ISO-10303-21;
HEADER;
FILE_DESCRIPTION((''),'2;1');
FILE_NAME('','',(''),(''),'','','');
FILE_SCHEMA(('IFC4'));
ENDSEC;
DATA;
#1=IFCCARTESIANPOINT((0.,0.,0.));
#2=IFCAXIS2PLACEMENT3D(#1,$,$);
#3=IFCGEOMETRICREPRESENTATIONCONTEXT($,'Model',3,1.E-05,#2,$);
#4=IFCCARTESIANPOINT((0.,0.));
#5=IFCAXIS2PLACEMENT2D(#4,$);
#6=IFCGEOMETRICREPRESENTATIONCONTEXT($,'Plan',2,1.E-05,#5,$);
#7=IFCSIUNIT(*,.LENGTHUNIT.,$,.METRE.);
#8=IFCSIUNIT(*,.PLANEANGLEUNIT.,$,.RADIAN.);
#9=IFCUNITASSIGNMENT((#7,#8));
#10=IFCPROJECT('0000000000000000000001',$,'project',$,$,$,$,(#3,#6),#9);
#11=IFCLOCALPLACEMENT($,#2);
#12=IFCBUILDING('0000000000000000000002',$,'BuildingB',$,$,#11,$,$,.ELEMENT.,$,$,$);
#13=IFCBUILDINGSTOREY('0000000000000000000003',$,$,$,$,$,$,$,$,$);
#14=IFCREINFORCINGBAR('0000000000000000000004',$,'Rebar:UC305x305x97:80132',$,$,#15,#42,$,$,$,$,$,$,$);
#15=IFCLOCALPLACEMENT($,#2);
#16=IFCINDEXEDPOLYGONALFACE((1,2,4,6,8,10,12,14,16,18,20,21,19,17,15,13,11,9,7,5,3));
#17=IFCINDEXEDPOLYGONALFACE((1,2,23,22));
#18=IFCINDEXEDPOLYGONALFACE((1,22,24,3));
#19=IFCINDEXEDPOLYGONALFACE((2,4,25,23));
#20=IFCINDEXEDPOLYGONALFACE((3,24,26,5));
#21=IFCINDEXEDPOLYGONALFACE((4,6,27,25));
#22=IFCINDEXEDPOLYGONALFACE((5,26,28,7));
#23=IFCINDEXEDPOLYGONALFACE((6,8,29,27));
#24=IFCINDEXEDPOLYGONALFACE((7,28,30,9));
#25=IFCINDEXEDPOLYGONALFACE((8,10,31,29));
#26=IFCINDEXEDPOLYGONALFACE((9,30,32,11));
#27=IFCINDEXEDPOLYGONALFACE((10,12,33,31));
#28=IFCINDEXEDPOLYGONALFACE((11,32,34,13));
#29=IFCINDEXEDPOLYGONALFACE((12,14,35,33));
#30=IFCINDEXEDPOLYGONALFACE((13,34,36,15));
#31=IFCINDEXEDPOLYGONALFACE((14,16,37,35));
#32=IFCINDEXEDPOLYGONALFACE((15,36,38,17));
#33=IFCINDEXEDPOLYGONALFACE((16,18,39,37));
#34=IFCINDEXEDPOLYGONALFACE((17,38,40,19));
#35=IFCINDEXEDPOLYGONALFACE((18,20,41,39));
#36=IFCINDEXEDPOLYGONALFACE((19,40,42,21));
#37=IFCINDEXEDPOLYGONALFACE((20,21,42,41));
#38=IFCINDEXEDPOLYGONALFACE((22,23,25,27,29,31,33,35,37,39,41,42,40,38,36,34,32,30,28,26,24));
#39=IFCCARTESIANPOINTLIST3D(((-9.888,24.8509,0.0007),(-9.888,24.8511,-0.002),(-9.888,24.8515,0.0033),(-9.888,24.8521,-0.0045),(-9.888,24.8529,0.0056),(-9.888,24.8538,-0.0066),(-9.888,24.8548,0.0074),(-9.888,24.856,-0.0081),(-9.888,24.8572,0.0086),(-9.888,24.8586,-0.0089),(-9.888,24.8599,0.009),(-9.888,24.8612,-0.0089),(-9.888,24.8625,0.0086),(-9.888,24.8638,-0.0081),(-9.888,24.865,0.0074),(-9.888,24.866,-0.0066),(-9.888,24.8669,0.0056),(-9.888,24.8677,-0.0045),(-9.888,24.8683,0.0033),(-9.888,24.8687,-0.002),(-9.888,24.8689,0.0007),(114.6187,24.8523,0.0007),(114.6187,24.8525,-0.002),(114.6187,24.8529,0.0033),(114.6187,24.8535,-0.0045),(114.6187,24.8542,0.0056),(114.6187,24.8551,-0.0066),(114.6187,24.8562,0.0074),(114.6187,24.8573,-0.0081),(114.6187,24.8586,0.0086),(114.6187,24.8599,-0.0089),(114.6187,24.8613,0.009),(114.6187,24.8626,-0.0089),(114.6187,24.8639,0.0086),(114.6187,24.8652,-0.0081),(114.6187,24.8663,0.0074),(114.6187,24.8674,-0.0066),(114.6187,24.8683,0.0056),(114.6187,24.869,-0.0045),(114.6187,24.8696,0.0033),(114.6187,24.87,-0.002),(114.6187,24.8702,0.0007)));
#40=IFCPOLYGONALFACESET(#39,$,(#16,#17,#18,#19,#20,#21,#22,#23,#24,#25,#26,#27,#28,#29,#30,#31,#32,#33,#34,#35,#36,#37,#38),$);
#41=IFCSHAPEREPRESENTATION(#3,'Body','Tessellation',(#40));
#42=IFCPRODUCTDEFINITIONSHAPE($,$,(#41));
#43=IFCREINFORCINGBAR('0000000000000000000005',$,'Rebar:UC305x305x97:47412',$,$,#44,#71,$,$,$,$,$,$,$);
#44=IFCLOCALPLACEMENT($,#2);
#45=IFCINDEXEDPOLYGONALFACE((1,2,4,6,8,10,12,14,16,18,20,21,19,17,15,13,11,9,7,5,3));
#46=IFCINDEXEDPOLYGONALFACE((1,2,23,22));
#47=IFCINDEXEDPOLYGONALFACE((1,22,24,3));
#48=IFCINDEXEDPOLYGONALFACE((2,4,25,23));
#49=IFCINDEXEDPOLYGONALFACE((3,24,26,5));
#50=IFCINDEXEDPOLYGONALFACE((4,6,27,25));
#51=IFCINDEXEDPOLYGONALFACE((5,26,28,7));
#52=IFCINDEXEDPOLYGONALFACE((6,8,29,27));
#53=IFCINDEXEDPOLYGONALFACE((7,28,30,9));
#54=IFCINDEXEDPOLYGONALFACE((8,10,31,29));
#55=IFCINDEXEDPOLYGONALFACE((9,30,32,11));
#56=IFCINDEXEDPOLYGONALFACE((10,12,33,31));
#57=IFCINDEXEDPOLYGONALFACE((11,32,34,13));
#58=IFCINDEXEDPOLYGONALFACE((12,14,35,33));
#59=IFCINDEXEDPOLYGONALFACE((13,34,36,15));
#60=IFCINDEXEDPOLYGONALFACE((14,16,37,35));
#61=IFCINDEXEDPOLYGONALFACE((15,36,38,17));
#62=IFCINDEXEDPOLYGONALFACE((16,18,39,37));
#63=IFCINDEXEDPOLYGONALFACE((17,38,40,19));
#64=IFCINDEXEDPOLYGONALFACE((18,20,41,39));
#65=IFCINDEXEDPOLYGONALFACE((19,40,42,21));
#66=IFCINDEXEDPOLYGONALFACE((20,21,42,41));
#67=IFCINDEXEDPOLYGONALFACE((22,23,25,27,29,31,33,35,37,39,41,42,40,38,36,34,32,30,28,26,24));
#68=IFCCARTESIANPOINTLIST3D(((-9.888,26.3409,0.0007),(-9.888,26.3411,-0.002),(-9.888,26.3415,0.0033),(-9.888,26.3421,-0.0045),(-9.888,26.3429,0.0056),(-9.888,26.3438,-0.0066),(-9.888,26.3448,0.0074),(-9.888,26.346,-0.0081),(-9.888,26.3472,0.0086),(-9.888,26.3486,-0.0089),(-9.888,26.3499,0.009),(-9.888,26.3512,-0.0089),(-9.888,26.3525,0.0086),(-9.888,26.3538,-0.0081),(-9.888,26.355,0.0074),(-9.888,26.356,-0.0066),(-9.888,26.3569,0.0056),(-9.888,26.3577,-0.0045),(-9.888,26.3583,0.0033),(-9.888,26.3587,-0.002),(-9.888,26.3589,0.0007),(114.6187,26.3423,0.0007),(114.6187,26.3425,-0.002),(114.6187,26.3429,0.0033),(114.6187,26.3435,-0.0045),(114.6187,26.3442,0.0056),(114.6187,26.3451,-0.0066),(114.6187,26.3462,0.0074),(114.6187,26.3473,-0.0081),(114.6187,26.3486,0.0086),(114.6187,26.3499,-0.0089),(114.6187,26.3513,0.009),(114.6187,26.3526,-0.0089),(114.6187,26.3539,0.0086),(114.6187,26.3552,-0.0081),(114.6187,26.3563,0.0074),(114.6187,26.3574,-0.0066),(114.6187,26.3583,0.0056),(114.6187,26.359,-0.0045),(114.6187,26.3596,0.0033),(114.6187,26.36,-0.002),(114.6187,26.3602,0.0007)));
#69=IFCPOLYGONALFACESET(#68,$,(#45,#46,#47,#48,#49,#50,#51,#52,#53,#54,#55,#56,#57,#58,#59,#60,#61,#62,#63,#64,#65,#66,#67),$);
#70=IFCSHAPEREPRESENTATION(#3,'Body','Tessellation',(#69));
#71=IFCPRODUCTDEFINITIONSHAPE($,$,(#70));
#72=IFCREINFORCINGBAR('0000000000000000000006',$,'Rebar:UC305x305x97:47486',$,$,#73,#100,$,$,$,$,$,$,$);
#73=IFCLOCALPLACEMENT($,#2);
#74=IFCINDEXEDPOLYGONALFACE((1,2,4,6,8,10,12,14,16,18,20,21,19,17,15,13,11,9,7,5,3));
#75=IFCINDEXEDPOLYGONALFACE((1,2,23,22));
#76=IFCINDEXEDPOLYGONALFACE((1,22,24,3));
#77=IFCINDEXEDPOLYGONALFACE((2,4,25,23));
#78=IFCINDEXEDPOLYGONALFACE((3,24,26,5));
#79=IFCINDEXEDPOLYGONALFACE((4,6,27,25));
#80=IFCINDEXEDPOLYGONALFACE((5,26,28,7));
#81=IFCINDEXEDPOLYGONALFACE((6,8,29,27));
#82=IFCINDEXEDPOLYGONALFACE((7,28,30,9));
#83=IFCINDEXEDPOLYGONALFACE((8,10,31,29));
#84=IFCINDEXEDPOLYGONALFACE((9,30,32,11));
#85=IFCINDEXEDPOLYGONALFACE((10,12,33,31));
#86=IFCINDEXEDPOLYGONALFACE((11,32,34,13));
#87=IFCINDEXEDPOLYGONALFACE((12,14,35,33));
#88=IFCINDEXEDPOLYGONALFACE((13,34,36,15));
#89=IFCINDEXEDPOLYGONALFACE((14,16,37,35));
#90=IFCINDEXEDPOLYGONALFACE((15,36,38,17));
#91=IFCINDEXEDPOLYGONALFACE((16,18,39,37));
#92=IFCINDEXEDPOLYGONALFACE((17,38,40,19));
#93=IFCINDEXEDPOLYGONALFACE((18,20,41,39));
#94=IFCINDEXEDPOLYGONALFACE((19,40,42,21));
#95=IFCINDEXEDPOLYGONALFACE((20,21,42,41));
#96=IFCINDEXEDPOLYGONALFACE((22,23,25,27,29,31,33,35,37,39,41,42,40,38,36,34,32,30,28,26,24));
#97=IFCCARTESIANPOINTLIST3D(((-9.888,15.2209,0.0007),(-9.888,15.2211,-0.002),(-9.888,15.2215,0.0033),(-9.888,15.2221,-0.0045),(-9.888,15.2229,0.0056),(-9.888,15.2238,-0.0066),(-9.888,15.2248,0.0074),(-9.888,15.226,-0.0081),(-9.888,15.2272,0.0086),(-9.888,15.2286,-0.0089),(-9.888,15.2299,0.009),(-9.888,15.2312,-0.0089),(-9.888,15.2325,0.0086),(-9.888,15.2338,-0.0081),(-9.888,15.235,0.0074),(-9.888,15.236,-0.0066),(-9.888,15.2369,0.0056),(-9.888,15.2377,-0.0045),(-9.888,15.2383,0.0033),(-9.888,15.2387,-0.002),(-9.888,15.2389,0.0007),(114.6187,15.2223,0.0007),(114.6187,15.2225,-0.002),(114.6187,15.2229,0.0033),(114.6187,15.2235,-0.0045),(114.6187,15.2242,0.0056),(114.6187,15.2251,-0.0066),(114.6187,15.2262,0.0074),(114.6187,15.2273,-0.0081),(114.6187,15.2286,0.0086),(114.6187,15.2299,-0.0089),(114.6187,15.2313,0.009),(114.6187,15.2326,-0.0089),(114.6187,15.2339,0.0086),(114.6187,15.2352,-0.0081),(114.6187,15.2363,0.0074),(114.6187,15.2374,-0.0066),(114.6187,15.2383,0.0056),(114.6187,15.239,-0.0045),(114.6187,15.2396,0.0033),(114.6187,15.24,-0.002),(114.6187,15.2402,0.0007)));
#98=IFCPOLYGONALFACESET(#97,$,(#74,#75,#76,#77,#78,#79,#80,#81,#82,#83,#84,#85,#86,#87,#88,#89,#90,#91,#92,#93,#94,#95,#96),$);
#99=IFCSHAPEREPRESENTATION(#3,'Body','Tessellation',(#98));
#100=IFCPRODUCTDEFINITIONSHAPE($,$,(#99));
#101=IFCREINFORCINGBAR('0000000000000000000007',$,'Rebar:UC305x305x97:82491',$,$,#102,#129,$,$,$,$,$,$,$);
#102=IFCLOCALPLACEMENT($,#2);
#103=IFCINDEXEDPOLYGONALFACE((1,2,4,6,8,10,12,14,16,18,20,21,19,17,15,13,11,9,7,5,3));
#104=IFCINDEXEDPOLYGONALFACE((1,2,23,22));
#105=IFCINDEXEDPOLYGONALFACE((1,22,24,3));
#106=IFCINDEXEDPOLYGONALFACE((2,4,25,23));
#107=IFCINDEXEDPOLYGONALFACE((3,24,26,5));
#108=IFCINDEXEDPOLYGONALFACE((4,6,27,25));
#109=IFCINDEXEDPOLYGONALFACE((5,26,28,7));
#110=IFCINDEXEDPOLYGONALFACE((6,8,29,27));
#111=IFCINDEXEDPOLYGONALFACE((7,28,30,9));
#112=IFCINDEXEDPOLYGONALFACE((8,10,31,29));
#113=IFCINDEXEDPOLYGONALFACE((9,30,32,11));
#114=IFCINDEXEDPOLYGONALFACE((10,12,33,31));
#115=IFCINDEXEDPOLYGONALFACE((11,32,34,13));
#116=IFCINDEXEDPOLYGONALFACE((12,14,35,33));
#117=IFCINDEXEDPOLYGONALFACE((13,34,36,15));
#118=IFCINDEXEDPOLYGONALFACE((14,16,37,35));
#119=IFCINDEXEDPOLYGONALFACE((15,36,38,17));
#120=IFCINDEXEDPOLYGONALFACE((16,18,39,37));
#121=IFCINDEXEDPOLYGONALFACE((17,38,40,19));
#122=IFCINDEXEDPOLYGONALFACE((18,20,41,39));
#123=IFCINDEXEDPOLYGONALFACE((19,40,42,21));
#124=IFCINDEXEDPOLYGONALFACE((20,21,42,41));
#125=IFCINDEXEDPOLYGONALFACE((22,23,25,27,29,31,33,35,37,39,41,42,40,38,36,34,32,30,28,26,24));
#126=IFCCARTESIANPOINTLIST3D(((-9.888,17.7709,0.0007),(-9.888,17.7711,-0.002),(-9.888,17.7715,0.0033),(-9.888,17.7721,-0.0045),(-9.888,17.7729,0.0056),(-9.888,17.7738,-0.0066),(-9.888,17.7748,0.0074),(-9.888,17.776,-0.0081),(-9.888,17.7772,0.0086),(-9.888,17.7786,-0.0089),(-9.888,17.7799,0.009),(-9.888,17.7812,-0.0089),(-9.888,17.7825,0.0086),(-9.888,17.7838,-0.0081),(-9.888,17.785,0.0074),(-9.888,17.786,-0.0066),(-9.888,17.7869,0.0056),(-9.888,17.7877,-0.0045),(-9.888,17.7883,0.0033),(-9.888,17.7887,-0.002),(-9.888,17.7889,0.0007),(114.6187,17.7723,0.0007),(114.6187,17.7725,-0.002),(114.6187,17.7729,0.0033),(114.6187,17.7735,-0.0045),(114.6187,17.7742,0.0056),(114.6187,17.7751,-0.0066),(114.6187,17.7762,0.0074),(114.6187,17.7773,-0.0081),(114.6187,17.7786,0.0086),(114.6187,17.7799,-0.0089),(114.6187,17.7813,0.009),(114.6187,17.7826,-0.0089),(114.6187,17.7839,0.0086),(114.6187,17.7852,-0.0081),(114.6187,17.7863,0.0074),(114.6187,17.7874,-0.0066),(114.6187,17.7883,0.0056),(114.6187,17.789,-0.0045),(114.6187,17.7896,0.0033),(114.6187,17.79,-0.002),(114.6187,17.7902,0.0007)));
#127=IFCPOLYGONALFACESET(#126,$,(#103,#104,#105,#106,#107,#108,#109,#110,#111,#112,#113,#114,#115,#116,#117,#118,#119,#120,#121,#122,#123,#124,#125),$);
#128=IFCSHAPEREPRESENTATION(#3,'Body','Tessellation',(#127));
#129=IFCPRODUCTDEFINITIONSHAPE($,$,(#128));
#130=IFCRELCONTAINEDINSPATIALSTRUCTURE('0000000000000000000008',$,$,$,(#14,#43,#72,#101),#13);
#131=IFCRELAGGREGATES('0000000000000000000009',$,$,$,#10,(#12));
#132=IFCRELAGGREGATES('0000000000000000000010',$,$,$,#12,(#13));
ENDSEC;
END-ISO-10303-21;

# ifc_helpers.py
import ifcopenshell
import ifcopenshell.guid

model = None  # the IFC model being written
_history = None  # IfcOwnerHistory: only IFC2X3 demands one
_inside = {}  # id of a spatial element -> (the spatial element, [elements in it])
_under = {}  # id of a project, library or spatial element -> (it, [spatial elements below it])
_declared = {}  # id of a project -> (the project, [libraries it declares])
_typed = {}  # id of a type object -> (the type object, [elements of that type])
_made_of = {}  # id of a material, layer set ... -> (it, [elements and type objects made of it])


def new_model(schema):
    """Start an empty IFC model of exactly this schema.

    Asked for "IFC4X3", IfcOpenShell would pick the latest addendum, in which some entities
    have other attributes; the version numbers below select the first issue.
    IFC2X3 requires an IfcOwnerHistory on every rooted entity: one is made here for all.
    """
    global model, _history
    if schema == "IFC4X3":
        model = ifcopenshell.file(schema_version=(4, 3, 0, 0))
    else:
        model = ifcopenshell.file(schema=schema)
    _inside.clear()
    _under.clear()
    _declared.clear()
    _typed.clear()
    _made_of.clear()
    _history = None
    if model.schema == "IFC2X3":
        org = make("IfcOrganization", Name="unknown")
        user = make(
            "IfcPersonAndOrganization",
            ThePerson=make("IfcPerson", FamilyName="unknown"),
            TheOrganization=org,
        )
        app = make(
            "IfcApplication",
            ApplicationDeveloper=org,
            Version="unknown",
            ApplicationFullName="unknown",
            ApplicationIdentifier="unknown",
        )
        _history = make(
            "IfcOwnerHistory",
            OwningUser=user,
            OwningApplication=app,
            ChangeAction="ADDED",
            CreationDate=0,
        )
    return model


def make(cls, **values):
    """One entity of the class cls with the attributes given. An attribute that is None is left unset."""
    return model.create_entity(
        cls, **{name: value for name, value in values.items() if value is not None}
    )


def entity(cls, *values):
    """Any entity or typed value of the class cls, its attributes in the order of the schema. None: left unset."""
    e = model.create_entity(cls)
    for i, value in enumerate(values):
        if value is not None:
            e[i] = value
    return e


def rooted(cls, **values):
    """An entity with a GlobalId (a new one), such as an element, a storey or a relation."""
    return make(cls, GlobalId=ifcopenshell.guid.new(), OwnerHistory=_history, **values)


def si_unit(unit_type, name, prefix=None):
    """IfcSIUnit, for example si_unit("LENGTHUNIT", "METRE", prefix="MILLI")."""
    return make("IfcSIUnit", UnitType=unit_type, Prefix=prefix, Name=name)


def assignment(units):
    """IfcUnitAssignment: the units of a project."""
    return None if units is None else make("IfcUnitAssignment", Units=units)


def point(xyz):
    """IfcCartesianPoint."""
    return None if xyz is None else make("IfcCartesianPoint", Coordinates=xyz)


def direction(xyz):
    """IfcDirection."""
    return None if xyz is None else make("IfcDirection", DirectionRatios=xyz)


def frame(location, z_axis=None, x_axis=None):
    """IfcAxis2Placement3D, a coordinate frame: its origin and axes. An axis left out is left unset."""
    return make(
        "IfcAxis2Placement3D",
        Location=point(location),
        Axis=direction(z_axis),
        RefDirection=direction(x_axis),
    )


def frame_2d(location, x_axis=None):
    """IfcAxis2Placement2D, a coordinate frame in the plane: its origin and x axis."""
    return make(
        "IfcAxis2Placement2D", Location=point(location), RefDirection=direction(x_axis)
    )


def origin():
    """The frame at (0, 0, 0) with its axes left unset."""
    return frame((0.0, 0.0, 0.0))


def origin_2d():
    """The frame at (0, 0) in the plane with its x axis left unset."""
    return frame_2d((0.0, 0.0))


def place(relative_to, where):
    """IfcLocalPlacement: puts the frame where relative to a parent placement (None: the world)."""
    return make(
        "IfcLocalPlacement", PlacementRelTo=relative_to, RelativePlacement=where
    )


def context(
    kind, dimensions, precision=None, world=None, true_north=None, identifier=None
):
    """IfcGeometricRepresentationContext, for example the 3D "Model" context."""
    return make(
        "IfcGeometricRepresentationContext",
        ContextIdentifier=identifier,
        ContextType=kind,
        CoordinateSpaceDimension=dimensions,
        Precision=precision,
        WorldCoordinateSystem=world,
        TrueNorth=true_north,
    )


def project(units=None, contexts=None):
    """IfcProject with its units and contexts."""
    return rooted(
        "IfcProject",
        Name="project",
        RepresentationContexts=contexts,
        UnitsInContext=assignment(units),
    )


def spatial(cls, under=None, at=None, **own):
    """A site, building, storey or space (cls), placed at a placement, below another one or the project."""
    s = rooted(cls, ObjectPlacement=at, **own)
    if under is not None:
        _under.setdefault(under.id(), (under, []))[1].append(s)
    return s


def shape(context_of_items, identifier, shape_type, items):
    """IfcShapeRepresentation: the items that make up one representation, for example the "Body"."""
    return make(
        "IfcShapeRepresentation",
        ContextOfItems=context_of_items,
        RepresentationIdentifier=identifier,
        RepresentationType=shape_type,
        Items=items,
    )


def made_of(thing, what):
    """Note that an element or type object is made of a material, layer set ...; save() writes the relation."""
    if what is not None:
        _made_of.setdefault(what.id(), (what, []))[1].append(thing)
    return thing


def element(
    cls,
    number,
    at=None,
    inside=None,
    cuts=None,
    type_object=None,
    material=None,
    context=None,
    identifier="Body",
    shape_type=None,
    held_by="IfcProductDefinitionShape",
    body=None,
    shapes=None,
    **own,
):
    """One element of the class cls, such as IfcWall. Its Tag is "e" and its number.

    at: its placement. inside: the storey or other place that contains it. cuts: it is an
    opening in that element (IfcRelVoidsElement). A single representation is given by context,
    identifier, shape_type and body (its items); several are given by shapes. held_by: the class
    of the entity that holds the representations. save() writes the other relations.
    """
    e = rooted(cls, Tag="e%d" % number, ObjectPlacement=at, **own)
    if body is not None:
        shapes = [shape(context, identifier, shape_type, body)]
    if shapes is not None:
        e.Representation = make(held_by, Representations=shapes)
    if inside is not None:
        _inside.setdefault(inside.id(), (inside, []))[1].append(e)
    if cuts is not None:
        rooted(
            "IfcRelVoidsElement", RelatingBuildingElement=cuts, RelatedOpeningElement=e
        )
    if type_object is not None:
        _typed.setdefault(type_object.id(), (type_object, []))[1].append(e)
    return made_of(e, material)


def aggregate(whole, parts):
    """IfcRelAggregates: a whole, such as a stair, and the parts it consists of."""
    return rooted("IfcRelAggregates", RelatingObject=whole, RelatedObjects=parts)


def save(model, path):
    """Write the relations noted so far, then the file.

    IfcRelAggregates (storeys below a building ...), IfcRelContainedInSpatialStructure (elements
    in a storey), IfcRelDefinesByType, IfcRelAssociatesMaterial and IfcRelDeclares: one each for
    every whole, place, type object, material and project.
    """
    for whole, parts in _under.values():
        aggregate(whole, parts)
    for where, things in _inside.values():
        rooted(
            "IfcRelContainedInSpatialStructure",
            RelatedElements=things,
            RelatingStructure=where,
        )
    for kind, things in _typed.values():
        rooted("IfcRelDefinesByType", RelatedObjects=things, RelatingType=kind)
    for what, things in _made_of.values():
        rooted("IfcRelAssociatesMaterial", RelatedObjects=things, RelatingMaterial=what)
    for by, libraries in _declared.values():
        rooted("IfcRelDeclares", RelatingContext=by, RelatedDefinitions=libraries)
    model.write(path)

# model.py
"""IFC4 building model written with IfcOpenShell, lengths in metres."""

from ifc_helpers import new_model, entity, si_unit, origin, origin_2d, place, context, project, spatial, element, save


model = new_model("IFC4")

# Units and contexts
model_context = context("Model", 3, precision=1e-05, world=origin())
plan_context = context("Plan", 2, precision=1e-05, world=origin_2d())
ifc_project = project(units=[si_unit("LENGTHUNIT", "METRE"), si_unit("PLANEANGLEUNIT", "RADIAN")], contexts=[model_context, plan_context])

# Building, storey
building_placement = place(None, origin())
building = spatial("IfcBuilding", under=ifc_project, at=building_placement, Name="BuildingB", CompositionType="ELEMENT")
storey = spatial("IfcBuildingStorey", under=building)

# Reinforcing bars
element("IfcReinforcingBar", 1, inside=storey, Name="Rebar:UC305x305x97:80132", context=model_context, shape_type="SweptSolid", body=[
    entity("IfcSurfaceCurveSweptAreaSolid", entity("IfcCircleProfileDef", "AREA", None, None, 0.009), None, entity("IfcPolyline", [entity("IfcCartesianPoint", [-9.888, 24.8599, 0.0]), entity("IfcCartesianPoint", [114.6187, 24.8613, 0.0])]), None, None, entity("IfcPlane", entity("IfcAxis2Placement3D", entity("IfcCartesianPoint", [-9.888, 24.8599, 0.0]), entity("IfcDirection", [0.0, 0.0, 1.0]), entity("IfcDirection", [1.0, 0.0, 0.0])))),
])
element("IfcReinforcingBar", 2, inside=storey, Name="Rebar:UC305x305x97:47412", context=model_context, shape_type="SweptSolid", body=[
    entity("IfcSurfaceCurveSweptAreaSolid", entity("IfcCircleProfileDef", "AREA", None, None, 0.009), None, entity("IfcPolyline", [entity("IfcCartesianPoint", [-9.888, 26.3499, 0.0]), entity("IfcCartesianPoint", [114.6187, 26.3513, 0.0])]), None, None, entity("IfcPlane", entity("IfcAxis2Placement3D", entity("IfcCartesianPoint", [-9.888, 26.3499, 0.0]), entity("IfcDirection", [0.0, 0.0, 1.0]), entity("IfcDirection", [1.0, 0.0, 0.0])))),
])
element("IfcReinforcingBar", 3, inside=storey, Name="Rebar:UC305x305x97:47486", context=model_context, shape_type="SweptSolid", body=[
    entity("IfcSurfaceCurveSweptAreaSolid", entity("IfcCircleProfileDef", "AREA", None, None, 0.009), None, entity("IfcPolyline", [entity("IfcCartesianPoint", [-9.888, 15.2299, 0.0]), entity("IfcCartesianPoint", [114.6187, 15.2313, 0.0])]), None, None, entity("IfcPlane", entity("IfcAxis2Placement3D", entity("IfcCartesianPoint", [-9.888, 15.2299, 0.0]), entity("IfcDirection", [0.0, 0.0, 1.0]), entity("IfcDirection", [1.0, 0.0, 0.0])))),
])
element("IfcReinforcingBar", 4, inside=storey, Name="Rebar:UC305x305x97:82491", context=model_context, shape_type="SweptSolid", body=[
    entity("IfcSurfaceCurveSweptAreaSolid", entity("IfcCircleProfileDef", "AREA", None, None, 0.009), None, entity("IfcPolyline", [entity("IfcCartesianPoint", [-9.888, 17.7799, 0.0]), entity("IfcCartesianPoint", [114.6187, 17.7813, 0.0])]), None, None, entity("IfcPlane", entity("IfcAxis2Placement3D", entity("IfcCartesianPoint", [-9.888, 17.7799, 0.0]), entity("IfcDirection", [0.0, 0.0, 1.0]), entity("IfcDirection", [1.0, 0.0, 0.0])))),
])

save(model, "model.ifc")
